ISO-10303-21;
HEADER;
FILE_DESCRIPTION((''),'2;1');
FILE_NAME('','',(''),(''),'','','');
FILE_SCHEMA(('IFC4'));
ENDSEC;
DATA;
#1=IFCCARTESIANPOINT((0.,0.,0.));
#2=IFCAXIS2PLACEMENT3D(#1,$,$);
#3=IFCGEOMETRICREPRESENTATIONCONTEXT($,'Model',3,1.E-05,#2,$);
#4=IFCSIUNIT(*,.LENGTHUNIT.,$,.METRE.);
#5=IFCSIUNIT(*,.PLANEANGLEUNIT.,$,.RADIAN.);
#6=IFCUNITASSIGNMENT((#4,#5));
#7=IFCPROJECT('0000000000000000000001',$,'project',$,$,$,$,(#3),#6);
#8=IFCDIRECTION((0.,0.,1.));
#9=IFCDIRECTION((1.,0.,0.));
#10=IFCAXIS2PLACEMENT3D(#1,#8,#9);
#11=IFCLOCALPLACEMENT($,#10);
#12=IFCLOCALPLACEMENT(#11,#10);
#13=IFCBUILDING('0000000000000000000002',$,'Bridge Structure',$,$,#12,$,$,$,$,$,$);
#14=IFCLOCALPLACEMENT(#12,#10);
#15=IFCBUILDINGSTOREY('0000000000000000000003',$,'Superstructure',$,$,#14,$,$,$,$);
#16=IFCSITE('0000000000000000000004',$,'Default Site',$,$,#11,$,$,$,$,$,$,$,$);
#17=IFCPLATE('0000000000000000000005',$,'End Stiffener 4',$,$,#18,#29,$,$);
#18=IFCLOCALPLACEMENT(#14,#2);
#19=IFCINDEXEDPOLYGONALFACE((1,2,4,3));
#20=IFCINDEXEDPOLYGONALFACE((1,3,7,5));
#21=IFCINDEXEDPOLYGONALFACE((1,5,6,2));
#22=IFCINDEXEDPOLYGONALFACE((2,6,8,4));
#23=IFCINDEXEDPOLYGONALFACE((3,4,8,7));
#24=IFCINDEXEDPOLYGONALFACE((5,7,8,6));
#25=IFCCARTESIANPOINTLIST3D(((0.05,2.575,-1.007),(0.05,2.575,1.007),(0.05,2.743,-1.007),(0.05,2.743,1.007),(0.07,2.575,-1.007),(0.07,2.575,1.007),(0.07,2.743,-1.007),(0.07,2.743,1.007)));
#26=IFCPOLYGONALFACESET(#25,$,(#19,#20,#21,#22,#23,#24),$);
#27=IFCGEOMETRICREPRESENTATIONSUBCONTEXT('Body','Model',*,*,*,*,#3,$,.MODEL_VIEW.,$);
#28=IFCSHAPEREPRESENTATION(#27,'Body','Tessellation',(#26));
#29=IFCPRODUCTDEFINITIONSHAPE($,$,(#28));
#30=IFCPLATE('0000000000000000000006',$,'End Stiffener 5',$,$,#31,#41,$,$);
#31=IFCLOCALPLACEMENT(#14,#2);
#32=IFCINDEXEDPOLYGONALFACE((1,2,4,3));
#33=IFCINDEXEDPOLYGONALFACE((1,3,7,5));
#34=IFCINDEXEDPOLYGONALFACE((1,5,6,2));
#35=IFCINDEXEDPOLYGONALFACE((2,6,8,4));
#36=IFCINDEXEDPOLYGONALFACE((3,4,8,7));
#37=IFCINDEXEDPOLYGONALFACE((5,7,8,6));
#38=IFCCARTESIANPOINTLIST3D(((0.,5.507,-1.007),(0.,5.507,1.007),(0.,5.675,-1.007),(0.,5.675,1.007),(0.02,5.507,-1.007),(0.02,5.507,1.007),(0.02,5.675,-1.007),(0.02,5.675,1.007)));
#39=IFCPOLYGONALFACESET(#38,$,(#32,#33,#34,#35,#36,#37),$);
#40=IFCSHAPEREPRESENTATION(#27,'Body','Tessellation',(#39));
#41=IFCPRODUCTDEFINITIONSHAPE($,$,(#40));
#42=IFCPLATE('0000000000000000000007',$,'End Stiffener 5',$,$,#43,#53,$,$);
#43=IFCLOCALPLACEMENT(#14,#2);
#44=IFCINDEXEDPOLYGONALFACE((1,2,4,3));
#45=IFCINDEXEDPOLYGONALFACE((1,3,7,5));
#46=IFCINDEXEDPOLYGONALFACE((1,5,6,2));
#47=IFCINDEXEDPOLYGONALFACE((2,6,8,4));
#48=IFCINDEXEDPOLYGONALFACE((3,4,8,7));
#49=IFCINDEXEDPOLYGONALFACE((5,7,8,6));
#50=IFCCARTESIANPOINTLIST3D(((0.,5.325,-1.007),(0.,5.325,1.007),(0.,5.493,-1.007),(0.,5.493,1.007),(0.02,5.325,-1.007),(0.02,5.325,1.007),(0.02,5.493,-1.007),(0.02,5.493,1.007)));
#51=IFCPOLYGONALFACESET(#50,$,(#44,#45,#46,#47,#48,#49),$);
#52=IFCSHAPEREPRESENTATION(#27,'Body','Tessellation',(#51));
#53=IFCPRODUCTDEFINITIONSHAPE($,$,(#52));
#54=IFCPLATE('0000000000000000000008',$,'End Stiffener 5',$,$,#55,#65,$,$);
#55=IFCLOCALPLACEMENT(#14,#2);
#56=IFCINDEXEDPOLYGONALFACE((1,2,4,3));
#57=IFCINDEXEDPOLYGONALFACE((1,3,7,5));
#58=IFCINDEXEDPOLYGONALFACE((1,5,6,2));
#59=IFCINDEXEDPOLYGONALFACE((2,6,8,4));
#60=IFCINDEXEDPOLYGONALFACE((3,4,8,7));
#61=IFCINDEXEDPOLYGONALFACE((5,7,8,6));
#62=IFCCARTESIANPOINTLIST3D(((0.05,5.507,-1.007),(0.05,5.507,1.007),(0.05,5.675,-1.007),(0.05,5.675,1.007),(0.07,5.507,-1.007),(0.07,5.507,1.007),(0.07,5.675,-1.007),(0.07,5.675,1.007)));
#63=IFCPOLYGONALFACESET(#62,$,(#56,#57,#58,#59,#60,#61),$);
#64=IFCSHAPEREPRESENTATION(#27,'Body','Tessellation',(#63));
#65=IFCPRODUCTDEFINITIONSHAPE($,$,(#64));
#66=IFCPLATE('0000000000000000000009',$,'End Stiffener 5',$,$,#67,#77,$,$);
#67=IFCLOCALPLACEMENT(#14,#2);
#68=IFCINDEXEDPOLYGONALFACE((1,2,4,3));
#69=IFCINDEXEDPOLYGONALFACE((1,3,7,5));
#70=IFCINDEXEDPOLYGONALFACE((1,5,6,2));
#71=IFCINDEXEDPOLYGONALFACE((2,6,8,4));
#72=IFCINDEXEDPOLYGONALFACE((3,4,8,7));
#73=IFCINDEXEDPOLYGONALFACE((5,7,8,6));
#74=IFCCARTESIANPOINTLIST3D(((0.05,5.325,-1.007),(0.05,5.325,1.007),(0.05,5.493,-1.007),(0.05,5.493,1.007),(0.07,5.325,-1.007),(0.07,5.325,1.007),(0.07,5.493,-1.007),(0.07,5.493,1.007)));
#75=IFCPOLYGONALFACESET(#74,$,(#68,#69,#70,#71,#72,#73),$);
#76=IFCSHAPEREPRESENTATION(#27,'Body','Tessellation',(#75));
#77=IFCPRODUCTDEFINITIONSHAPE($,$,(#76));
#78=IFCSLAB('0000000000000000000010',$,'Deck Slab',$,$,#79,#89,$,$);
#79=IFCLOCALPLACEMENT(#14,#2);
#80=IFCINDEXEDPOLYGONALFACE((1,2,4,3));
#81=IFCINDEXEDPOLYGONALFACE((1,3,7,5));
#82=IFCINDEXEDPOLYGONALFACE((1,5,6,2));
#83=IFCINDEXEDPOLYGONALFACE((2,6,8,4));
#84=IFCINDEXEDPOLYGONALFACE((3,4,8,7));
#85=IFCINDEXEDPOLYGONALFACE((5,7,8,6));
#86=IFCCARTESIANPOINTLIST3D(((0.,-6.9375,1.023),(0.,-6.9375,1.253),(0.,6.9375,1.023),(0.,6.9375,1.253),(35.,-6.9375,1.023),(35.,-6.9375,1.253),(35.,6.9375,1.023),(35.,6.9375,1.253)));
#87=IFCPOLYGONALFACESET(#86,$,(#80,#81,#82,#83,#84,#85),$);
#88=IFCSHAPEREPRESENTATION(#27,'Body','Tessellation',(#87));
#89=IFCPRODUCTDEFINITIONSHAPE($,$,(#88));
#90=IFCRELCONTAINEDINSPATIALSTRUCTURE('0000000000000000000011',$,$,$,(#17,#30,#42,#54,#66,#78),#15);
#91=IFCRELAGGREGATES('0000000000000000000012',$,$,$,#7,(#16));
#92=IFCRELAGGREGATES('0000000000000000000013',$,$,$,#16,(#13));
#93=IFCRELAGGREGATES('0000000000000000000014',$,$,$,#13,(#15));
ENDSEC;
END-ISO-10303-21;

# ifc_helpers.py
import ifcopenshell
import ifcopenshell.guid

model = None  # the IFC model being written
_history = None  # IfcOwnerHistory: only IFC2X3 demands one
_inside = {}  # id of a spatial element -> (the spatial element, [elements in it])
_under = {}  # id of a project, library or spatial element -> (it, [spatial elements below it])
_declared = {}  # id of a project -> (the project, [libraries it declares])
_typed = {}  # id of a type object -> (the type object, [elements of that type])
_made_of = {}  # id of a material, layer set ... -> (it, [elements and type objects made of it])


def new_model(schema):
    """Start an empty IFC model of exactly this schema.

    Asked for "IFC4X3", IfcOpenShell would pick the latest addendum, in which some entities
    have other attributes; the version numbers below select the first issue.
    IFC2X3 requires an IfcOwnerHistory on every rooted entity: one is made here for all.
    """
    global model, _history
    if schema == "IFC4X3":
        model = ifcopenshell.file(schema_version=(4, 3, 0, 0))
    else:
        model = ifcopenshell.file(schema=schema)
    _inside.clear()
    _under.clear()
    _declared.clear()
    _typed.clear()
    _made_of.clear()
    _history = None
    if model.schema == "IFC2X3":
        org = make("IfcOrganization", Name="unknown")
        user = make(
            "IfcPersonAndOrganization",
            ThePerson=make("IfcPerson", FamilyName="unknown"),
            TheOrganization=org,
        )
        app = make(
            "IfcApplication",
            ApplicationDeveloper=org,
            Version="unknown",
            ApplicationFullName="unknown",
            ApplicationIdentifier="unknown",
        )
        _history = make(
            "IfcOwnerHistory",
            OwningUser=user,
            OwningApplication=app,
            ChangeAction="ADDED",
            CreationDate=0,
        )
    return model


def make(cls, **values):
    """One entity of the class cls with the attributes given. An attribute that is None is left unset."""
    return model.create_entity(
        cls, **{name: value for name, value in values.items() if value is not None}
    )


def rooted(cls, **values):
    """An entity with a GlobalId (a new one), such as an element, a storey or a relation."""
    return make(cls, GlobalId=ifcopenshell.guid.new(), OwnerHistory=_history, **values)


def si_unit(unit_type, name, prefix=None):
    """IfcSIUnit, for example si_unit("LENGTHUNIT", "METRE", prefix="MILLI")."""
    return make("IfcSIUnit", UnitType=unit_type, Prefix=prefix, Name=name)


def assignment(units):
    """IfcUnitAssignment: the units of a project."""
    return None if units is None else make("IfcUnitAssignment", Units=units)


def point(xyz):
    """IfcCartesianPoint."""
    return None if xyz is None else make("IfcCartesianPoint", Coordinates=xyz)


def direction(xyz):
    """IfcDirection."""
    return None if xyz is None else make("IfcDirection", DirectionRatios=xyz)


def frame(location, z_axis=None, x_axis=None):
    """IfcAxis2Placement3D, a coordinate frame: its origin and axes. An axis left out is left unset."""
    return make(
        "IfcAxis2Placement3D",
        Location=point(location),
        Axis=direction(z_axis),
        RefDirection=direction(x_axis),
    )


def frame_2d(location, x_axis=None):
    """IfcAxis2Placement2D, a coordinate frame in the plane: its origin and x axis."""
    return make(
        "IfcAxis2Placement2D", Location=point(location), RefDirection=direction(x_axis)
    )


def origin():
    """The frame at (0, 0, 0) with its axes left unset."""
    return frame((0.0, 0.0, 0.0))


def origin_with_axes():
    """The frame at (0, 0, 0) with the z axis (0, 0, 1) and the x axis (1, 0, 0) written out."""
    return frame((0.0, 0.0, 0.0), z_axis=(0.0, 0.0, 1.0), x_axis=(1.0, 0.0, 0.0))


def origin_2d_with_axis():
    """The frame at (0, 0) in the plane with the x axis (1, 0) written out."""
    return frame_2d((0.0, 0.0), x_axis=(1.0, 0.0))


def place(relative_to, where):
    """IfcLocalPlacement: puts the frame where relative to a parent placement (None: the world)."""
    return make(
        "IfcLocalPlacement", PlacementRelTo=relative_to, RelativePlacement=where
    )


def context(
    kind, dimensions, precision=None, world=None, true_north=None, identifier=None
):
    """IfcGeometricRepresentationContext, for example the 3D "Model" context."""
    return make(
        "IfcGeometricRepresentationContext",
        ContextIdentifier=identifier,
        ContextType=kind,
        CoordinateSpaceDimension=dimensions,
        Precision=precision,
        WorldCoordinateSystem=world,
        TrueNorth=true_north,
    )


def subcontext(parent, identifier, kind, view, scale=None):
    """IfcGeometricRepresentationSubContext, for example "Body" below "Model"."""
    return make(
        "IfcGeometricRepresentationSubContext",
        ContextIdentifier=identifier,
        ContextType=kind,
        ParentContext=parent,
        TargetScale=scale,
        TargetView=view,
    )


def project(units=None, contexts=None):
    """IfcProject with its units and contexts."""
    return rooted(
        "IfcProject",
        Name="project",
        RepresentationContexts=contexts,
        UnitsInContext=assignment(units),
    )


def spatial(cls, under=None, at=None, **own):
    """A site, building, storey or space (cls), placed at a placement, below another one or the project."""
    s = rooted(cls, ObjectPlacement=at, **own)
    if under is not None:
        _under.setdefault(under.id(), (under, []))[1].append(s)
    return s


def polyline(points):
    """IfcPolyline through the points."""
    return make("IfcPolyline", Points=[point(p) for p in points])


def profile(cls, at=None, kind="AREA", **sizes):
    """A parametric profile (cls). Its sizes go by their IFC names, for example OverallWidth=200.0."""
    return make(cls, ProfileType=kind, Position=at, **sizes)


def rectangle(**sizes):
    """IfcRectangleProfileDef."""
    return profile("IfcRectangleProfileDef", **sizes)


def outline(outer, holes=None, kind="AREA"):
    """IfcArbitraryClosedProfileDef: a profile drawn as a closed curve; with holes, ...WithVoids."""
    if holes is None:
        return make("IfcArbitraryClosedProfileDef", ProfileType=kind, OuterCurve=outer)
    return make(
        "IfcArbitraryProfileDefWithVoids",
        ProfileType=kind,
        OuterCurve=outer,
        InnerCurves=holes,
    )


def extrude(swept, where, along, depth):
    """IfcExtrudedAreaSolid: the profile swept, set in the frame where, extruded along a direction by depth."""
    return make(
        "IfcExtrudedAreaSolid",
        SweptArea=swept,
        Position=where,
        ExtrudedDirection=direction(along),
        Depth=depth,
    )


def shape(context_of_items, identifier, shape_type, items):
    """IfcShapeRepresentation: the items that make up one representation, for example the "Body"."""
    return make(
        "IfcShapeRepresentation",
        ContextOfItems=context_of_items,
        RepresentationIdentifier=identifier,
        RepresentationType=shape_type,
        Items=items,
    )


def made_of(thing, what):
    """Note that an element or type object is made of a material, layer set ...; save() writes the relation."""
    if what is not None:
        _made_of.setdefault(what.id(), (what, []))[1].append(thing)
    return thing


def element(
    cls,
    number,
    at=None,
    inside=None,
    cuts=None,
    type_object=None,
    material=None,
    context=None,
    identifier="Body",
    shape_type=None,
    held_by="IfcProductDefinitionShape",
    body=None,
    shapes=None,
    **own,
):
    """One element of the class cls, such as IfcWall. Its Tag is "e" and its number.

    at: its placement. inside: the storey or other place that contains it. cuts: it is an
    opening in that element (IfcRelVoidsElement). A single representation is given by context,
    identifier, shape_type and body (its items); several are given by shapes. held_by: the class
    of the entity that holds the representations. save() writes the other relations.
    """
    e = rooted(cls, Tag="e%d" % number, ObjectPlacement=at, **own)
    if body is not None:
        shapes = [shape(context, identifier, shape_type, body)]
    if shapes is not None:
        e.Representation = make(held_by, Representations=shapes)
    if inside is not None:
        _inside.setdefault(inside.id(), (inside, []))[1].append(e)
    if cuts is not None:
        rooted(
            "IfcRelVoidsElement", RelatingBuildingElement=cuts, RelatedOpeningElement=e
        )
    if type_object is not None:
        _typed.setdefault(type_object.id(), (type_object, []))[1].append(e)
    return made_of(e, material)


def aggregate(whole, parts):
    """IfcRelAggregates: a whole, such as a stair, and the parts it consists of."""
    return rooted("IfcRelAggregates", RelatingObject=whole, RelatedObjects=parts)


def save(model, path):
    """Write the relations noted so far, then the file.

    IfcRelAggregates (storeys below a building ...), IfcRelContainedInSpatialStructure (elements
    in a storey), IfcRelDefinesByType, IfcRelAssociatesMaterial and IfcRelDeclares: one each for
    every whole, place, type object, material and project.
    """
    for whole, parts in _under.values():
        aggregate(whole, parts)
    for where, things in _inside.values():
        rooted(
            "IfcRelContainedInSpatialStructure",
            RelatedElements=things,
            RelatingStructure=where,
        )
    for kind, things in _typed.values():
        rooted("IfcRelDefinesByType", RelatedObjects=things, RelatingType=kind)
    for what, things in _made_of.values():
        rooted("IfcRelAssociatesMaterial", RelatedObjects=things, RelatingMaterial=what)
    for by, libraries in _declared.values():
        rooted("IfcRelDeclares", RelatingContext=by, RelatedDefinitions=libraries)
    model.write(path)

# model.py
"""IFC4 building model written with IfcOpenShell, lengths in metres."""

from ifc_helpers import new_model, si_unit, frame, origin, origin_with_axes, origin_2d_with_axis, place, context, subcontext, project, spatial, polyline, rectangle, outline, extrude, element, save


model = new_model("IFC4")

# Units and contexts
model_context = context("Model", 3, precision=1e-05, world=origin())
body_context = subcontext(model_context, "Body", "Model", "MODEL_VIEW")
ifc_project = project(units=[si_unit("LENGTHUNIT", "METRE"), si_unit("PLANEANGLEUNIT", "RADIAN")], contexts=[model_context])

# Site, building, storey
site_placement = place(None, origin_with_axes())
site = spatial("IfcSite", under=ifc_project, at=site_placement, Name="Default Site")
building_placement = place(site_placement, origin_with_axes())
building = spatial("IfcBuilding", under=site, at=building_placement, Name="Bridge Structure")
storey_placement = place(building_placement, origin_with_axes())
storey = spatial("IfcBuildingStorey", under=building, at=storey_placement, Name="Superstructure")

# Plates
for number, where, z_axis, x_axis, name in (
    (1, (0.06, 2.659, -1.007), (0.0, 0.0, 1.0), (1.0, 0.0, 0.0), "End Stiffener 4"),
    (2, (0.01, 5.591, -1.007), (0.0, 0.0, 1.0), (1.0, 0.0, 0.0), "End Stiffener 5"),
    (3, (0.01, 5.409, -1.007), (0.0, 0.0, 1.0), (1.0, 0.0, 0.0), "End Stiffener 5"),
    (4, (0.06, 5.591, -1.007), (0.0, 0.0, 1.0), (1.0, 0.0, 0.0), "End Stiffener 5"),
    (5, (0.06, 5.409, -1.007), (0.0, 0.0, 1.0), (1.0, 0.0, 0.0), "End Stiffener 5"),
):
    element("IfcPlate", number, at=place(storey_placement, frame(where, z_axis=z_axis, x_axis=x_axis)), inside=storey, Name=name, context=body_context, shape_type="SweptSolid", body=[
        extrude(rectangle(XDim=0.02, YDim=0.168, at=origin_2d_with_axis()), origin_with_axes(), (0.0, 0.0, 1.0), 2.014),
    ])

# Slab
slab_placement = place(storey_placement, frame((0.0, 0.0, 1.023), z_axis=(0.0, 0.0, 1.0), x_axis=(1.0, 0.0, 0.0)))
element("IfcSlab", 6, at=slab_placement, inside=storey, Name="Deck Slab", context=body_context, shape_type="SweptSolid", body=[
    extrude(outline(polyline([(0.0, -6.9375), (35.0, -6.9375), (35.0, 6.9375), (0.0, 6.9375), (0.0, -6.9375)])), origin_with_axes(), (0.0, 0.0, 1.0), 0.23),
])

save(model, "model.ifc")
